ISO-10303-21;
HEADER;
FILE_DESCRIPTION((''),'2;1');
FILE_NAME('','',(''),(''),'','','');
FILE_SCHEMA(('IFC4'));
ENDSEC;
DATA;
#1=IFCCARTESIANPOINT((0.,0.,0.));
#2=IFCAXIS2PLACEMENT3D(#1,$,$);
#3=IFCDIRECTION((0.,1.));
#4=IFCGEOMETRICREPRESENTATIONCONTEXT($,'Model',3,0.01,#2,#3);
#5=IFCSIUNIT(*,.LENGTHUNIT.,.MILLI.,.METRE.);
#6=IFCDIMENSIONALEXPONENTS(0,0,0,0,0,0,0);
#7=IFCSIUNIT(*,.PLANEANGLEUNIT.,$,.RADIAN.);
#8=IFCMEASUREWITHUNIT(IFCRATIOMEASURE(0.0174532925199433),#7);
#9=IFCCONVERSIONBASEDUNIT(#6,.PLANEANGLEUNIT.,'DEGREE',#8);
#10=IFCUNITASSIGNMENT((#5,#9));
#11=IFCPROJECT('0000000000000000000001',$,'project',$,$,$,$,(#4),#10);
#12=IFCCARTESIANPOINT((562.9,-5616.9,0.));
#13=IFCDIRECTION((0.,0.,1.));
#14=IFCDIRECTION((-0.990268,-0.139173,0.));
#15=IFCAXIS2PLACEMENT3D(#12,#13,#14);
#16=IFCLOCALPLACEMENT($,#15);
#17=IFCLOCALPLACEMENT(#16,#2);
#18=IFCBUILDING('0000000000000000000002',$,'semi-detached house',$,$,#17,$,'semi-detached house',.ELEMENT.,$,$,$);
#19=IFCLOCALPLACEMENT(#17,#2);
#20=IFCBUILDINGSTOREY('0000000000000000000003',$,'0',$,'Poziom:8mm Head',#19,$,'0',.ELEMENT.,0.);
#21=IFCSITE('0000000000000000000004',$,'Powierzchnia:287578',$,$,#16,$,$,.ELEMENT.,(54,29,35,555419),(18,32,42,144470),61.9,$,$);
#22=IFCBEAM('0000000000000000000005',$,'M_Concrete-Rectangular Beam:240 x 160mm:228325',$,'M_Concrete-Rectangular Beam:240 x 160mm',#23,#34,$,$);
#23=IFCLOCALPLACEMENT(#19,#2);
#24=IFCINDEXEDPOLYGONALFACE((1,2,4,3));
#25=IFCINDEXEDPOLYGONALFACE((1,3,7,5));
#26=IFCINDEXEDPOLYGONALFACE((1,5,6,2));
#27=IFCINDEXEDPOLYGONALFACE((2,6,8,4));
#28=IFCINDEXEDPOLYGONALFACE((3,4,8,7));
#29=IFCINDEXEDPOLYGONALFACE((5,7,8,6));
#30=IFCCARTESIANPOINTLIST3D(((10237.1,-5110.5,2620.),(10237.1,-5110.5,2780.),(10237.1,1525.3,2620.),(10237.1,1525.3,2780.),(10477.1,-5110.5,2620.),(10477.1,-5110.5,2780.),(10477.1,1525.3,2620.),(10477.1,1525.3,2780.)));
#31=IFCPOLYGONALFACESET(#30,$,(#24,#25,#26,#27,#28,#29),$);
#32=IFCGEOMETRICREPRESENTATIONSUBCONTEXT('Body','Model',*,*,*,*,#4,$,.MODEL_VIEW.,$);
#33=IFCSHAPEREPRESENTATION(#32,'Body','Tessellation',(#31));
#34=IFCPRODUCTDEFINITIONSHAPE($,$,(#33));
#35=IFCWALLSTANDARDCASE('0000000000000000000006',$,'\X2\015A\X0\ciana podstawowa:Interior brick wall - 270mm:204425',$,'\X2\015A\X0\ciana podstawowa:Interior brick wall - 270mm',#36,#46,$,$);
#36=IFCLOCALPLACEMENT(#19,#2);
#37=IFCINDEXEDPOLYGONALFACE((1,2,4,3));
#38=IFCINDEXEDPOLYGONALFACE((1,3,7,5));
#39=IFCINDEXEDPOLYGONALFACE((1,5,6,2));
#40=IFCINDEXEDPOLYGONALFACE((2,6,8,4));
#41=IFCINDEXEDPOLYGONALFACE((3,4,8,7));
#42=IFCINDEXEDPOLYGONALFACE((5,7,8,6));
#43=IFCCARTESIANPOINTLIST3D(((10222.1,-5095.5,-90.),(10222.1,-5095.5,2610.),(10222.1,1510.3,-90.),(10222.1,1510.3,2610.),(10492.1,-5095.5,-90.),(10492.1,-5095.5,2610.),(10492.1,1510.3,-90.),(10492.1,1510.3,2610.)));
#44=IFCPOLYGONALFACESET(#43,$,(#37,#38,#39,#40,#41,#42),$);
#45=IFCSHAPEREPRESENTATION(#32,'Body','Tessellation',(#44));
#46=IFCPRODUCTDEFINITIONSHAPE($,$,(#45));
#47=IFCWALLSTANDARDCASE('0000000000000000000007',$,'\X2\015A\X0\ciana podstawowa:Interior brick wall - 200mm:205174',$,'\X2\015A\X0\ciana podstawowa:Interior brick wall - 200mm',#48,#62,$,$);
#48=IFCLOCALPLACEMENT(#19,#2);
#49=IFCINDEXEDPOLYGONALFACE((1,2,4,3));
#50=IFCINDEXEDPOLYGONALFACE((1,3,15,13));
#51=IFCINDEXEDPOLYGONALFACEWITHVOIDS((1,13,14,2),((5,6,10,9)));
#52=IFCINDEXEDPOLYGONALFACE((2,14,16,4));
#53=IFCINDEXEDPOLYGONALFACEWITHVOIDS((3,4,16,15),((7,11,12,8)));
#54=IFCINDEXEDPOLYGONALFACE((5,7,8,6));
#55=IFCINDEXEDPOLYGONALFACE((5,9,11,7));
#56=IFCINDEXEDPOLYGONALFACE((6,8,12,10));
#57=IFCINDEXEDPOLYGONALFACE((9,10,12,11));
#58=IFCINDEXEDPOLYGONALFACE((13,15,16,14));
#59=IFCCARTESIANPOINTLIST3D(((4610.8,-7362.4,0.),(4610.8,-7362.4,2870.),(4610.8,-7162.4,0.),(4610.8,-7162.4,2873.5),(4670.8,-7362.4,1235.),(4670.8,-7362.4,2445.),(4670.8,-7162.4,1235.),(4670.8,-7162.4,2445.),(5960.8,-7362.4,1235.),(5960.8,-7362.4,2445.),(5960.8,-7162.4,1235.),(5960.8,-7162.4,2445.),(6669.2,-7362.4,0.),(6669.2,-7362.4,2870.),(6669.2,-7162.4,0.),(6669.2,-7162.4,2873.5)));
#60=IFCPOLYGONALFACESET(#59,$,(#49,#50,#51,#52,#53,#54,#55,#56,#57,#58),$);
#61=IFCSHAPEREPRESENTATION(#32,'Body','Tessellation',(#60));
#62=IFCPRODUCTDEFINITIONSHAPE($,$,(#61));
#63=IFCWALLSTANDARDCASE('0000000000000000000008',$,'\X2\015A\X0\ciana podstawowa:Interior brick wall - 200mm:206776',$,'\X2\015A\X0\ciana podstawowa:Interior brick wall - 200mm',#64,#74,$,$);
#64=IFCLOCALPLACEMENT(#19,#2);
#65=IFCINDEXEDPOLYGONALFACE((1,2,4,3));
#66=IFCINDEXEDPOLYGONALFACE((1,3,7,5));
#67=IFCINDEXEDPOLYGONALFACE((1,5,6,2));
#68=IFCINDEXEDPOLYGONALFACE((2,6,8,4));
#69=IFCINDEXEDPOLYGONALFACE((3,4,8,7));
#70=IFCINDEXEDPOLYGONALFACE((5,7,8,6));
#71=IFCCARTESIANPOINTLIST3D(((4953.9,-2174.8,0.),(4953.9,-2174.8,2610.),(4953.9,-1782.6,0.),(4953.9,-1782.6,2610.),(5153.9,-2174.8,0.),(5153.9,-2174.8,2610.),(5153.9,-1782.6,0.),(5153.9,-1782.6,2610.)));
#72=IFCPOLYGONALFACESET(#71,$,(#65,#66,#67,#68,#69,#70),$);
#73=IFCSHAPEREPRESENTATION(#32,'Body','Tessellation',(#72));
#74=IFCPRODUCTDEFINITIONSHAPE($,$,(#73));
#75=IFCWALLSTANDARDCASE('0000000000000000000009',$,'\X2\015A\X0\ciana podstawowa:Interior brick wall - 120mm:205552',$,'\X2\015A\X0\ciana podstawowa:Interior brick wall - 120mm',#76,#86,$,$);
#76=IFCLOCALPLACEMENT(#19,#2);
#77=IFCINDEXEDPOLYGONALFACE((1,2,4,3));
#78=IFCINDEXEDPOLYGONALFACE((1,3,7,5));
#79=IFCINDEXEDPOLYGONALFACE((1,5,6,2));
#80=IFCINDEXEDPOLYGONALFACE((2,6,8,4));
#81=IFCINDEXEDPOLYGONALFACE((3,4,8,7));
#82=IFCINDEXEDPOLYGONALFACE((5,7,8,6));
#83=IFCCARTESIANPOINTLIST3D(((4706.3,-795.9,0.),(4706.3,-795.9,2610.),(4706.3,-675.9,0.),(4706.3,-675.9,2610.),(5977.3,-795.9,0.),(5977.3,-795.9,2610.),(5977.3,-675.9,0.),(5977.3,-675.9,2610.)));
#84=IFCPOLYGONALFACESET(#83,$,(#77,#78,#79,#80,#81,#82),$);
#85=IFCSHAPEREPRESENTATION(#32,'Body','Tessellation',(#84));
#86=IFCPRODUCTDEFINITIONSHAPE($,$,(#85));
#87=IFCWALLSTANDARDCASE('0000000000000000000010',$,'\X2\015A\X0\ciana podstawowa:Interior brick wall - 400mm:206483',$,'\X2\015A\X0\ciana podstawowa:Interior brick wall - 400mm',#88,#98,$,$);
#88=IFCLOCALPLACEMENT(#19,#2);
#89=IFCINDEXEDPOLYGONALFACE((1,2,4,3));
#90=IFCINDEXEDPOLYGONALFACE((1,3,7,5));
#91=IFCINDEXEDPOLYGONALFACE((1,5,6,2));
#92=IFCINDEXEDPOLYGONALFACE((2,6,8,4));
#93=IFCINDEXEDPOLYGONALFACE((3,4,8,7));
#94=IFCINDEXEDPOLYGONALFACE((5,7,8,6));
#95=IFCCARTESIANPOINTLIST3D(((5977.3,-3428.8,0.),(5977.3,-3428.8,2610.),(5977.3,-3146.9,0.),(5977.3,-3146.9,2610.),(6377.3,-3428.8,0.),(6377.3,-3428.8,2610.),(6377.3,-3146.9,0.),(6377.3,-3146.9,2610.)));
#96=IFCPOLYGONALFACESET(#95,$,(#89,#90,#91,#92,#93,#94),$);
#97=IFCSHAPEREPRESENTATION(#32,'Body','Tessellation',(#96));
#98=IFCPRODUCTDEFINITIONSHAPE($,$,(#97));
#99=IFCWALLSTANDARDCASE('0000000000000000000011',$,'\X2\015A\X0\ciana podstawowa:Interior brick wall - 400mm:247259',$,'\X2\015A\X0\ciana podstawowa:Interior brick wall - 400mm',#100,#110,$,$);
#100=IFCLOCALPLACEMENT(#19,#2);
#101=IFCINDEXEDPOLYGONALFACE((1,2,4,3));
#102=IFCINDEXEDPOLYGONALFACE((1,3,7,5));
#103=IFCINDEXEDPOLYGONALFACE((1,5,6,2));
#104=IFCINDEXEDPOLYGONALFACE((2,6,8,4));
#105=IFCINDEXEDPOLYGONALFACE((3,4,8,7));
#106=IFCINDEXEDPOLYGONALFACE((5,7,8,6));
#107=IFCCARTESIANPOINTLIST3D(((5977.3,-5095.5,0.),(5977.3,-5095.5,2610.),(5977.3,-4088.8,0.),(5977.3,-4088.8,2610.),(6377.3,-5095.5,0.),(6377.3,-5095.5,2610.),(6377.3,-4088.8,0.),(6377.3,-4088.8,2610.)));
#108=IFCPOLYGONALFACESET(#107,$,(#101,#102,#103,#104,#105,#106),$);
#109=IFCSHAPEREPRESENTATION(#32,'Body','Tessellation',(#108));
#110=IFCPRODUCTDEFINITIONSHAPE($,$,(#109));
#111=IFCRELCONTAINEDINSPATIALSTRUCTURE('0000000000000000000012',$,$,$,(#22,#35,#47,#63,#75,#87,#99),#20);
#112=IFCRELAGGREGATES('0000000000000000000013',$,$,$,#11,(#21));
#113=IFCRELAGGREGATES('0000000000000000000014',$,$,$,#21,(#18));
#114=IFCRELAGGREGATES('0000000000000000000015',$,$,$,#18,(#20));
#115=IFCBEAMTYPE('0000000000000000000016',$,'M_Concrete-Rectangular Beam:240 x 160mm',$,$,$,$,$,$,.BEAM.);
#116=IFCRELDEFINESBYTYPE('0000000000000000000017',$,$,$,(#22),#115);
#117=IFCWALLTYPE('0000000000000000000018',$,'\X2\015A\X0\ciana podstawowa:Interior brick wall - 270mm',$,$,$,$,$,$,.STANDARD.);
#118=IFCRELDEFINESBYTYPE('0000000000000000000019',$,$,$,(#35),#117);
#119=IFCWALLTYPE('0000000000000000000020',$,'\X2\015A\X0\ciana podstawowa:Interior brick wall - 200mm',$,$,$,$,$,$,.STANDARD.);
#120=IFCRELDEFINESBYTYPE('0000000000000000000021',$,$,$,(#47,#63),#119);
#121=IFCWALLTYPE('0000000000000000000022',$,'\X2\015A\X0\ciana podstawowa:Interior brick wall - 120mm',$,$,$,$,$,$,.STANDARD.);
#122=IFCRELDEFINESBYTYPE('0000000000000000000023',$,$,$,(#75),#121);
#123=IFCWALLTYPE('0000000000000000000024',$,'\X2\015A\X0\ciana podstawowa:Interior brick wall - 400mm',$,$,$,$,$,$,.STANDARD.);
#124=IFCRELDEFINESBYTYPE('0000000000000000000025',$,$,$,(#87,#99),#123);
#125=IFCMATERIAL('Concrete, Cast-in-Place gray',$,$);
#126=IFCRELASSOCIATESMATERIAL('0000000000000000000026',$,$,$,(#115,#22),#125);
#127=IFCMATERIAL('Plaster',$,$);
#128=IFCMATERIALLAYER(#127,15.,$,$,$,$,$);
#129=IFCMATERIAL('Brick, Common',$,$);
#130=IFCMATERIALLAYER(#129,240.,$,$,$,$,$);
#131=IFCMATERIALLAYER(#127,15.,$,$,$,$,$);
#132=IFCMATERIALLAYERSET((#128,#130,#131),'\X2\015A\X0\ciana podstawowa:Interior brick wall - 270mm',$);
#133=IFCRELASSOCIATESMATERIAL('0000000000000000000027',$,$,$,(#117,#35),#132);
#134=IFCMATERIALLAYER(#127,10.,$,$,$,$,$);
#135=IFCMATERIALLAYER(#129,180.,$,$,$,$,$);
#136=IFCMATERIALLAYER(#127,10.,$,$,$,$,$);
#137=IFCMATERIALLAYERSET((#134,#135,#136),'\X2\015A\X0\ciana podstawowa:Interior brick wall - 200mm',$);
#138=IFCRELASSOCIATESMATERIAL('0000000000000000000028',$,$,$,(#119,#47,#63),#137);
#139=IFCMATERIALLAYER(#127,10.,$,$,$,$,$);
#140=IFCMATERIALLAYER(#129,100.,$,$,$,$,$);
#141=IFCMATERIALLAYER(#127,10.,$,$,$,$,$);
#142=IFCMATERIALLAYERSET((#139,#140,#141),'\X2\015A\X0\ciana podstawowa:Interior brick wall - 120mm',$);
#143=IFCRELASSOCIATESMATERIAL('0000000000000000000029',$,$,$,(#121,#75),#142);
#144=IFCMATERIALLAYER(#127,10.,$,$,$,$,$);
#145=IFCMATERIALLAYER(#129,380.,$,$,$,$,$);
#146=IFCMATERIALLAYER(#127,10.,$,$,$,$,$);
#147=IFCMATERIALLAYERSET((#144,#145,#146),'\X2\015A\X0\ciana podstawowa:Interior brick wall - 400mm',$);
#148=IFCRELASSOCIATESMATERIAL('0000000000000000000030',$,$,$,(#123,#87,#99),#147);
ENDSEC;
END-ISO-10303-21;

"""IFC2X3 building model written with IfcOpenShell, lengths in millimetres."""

from ifc_helpers import new_model, entity, si_unit, converted_unit, direction, frame, frame_2d, origin, place, context, subcontext, project, spatial, polyline, rectangle, extrude, clip, bounded_halfspace, material, layer, layer_set, layer_usage, type_object, element, save


model = new_model("IFC2X3")

# Units and contexts
model_context = context("Model", 3, precision=0.01, world=origin(), true_north=direction((0.0, 1.0)))
body_context = subcontext(model_context, "Body", "Model", "MODEL_VIEW")
ifc_project = project(units=[si_unit("LENGTHUNIT", "METRE", prefix="MILLI"), converted_unit("PLANEANGLEUNIT", "DEGREE", entity("IfcRatioMeasure", 0.0174532925199433), si_unit("PLANEANGLEUNIT", "RADIAN"), dimensions=[0, 0, 0, 0, 0, 0, 0])], contexts=[model_context])

# Site, building, storey
site_placement = place(None, frame((562.9, -5616.9, 0.0), z_axis=(0.0, 0.0, 1.0), x_axis=(-0.990268, -0.139173, 0.0)))
site = spatial("IfcSite", under=ifc_project, at=site_placement, Name="Powierzchnia:287578", CompositionType="ELEMENT", RefLatitude=(54, 29, 35, 555419), RefLongitude=(18, 32, 42, 144470), RefElevation=61.9)
building_placement = place(site_placement, origin())
building = spatial("IfcBuilding", under=site, at=building_placement, Name="semi-detached house", LongName="semi-detached house", CompositionType="ELEMENT")
storey_placement = place(building_placement, origin())
storey = spatial("IfcBuildingStorey", under=building, at=storey_placement, Name="0", ObjectType="Poziom:8mm Head", LongName="0", CompositionType="ELEMENT", Elevation=0.0)

# Beam
ifc_material_1 = material(Name="Concrete, Cast-in-Place gray")
beam_type_1 = type_object("IfcBeamType", Name="M_Concrete-Rectangular Beam:240 x 160mm", PredefinedType="BEAM", material=ifc_material_1)
beam_1_placement = place(storey_placement, frame((10357.1, 1865.3, 2780.0), z_axis=(0.0, 0.0, 1.0), x_axis=(0.0, -1.0, 0.0)))
element("IfcBeam", 1, at=beam_1_placement, inside=storey, type_object=beam_type_1, material=ifc_material_1, Name="M_Concrete-Rectangular Beam:240 x 160mm:228325", ObjectType="M_Concrete-Rectangular Beam:240 x 160mm", context=body_context, shape_type="SweptSolid", body=[
    extrude(rectangle(XDim=160.0, YDim=240.0, at=frame_2d((0.0, 0.0), x_axis=(1.0, 0.0))), frame((340.0, 0.0, -80.0), z_axis=(1.0, 0.0, 0.0), x_axis=(0.0, 0.0, -1.0)), (0.0, 0.0, 1.0), 6635.8),
])

# Wall
ifc_material_2 = material(Name="Plaster")
ifc_layer_1 = layer(ifc_material_2, 15.0)
ifc_material_3 = material(Name="Brick, Common")
ifc_layer_2 = layer(ifc_material_3, 240.0)
ifc_layer_3 = layer(ifc_material_2, 15.0)
ifc_layer_set_1 = layer_set([ifc_layer_1, ifc_layer_2, ifc_layer_3], Name="Ściana podstawowa:Interior brick wall - 270mm")
ifc_layer_usage_1 = layer_usage(ifc_layer_set_1, "AXIS2", "NEGATIVE", 135.0)
wall_type_1 = type_object("IfcWallType", Name="Ściana podstawowa:Interior brick wall - 270mm", PredefinedType="STANDARD", material=ifc_layer_set_1)
wall_1_placement = place(storey_placement, frame((10357.1, -5095.5, -90.0), z_axis=(0.0, 0.0, 1.0), x_axis=(0.0, 1.0, 0.0)))
element("IfcWallStandardCase", 2, at=wall_1_placement, inside=storey, type_object=wall_type_1, material=ifc_layer_usage_1, Name="Ściana podstawowa:Interior brick wall - 270mm:204425", ObjectType="Ściana podstawowa:Interior brick wall - 270mm", context=body_context, shape_type="SweptSolid", body=[
    extrude(rectangle(XDim=6605.8, YDim=270.0, at=frame_2d((3302.9, 0.0), x_axis=(-1.0, 0.0))), origin(), (0.0, 0.0, 1.0), 2700.0),
])

# Wall, opening
ifc_layer_4 = layer(ifc_material_2, 10.0)
ifc_layer_5 = layer(ifc_material_3, 180.0)
ifc_layer_6 = layer(ifc_material_2, 10.0)
ifc_layer_set_2 = layer_set([ifc_layer_4, ifc_layer_5, ifc_layer_6], Name="Ściana podstawowa:Interior brick wall - 200mm")
ifc_layer_usage_2 = layer_usage(ifc_layer_set_2, "AXIS2", "NEGATIVE", 100.0)
wall_type_2 = type_object("IfcWallType", Name="Ściana podstawowa:Interior brick wall - 200mm", PredefinedType="STANDARD", material=ifc_layer_set_2)
wall_2_placement = place(storey_placement, frame((6669.2, -7262.4, 0.0), z_axis=(0.0, 0.0, 1.0), x_axis=(-1.0, 0.0, 0.0)))
wall_2 = element("IfcWallStandardCase", 3, at=wall_2_placement, inside=storey, type_object=wall_type_2, material=ifc_layer_usage_2, Name="Ściana podstawowa:Interior brick wall - 200mm:205174", ObjectType="Ściana podstawowa:Interior brick wall - 200mm", context=body_context, shape_type="Clipping", body=[
    clip(clip(extrude(rectangle(XDim=2058.3, YDim=200.0, at=frame_2d((1029.2, 0.0), x_axis=(-1.0, 0.0))), origin(), (0.0, 0.0, 1.0), 2873.5), bounded_halfspace(frame((0.0, -100.0, 2873.5), z_axis=(0.0, 0.017452, 0.999848), x_axis=(-1.0, 0.0, 0.0)), False, frame((0.0, -100.0, 2873.5)), polyline([(0.0, 0.0), (2058.3, 0.0), (2058.3, 200.0), (0.0, 200.0), (0.0, 0.0)]))), bounded_halfspace(frame((2058.3, -100.0, 0.0), z_axis=(0.0, 0.0, 1.0), x_axis=(0.0, 1.0, 0.0)), True, frame((2058.3, -100.0, 0.0), z_axis=(0.0, 0.0, 1.0), x_axis=(0.0, 1.0, 0.0)), polyline([(0.0, 0.0), (200.0, 0.0), (200.0, 2058.3), (0.0, 2058.3), (0.0, 0.0)]))),
])
opening_1_placement = place(wall_2_placement, frame((708.3, -100.0, 1235.0)))
element("IfcOpeningElement", 4, at=opening_1_placement, cuts=wall_2, ObjectType="Opening", context=body_context, shape_type="SweptSolid", body=[
    extrude(rectangle(XDim=1210.0, YDim=1290.0, at=frame_2d((605.0, 645.0), x_axis=(-1.0, 0.0))), frame((0.0, 0.0, 0.0), z_axis=(0.0, 1.0, 0.0), x_axis=(0.0, 0.0, 1.0)), (0.0, 0.0, 1.0), 200.0),
])

# Walls
ifc_layer_usage_3 = layer_usage(ifc_layer_set_2, "AXIS2", "NEGATIVE", 100.0)
wall_3_placement = place(storey_placement, frame((5053.9, -1782.6, 0.0), z_axis=(0.0, 0.0, 1.0), x_axis=(0.0, -1.0, 0.0)))
element("IfcWallStandardCase", 5, at=wall_3_placement, inside=storey, type_object=wall_type_2, material=ifc_layer_usage_3, Name="Ściana podstawowa:Interior brick wall - 200mm:206776", ObjectType="Ściana podstawowa:Interior brick wall - 200mm", context=body_context, shape_type="Clipping", body=[
    clip(extrude(rectangle(XDim=392.1, YDim=200.0, at=frame_2d((196.1, 0.0), x_axis=(-1.0, 0.0))), origin(), (0.0, 0.0, 1.0), 2610.0), bounded_halfspace(frame((392.1, -100.0, 0.0)), True, frame((392.1, -100.0, 0.0)), polyline([(0.0, 0.0), (0.0, 200.0), (-392.1, 200.0), (-392.1, 80.0), (-392.1, 0.0), (-272.1, 0.0), (0.0, 0.0)]))),
])
ifc_layer_7 = layer(ifc_material_2, 10.0)
ifc_layer_8 = layer(ifc_material_3, 100.0)
ifc_layer_9 = layer(ifc_material_2, 10.0)
ifc_layer_set_3 = layer_set([ifc_layer_7, ifc_layer_8, ifc_layer_9], Name="Ściana podstawowa:Interior brick wall - 120mm")
ifc_layer_usage_4 = layer_usage(ifc_layer_set_3, "AXIS2", "NEGATIVE", 60.0)
wall_type_3 = type_object("IfcWallType", Name="Ściana podstawowa:Interior brick wall - 120mm", PredefinedType="STANDARD", material=ifc_layer_set_3)
wall_4_placement = place(storey_placement, frame((5977.3, -735.9, 0.0), z_axis=(0.0, 0.0, 1.0), x_axis=(-1.0, 0.0, 0.0)))
element("IfcWallStandardCase", 6, at=wall_4_placement, inside=storey, type_object=wall_type_3, material=ifc_layer_usage_4, Name="Ściana podstawowa:Interior brick wall - 120mm:205552", ObjectType="Ściana podstawowa:Interior brick wall - 120mm", context=body_context, shape_type="Clipping", body=[
    clip(extrude(rectangle(XDim=1271.0, YDim=120.0, at=frame_2d((635.5, 0.0), x_axis=(-1.0, 0.0))), origin(), (0.0, 0.0, 1.0), 2610.0), bounded_halfspace(frame((1271.0, -60.0, 0.0), z_axis=(0.0, 0.0, 1.0), x_axis=(0.0, 1.0, 0.0)), True, frame((1271.0, -60.0, 0.0), z_axis=(0.0, 0.0, 1.0), x_axis=(0.0, 1.0, 0.0)), polyline([(0.0, 0.0), (120.0, 0.0), (120.0, 1271.0), (0.0, 1271.0), (0.0, 0.0)]))),
])
ifc_layer_10 = layer(ifc_material_2, 10.0)
ifc_layer_11 = layer(ifc_material_3, 380.0)
ifc_layer_12 = layer(ifc_material_2, 10.0)
ifc_layer_set_4 = layer_set([ifc_layer_10, ifc_layer_11, ifc_layer_12], Name="Ściana podstawowa:Interior brick wall - 400mm")
ifc_layer_usage_5 = layer_usage(ifc_layer_set_4, "AXIS2", "POSITIVE", -200.0)
wall_type_4 = type_object("IfcWallType", Name="Ściana podstawowa:Interior brick wall - 400mm", PredefinedType="STANDARD", material=ifc_layer_set_4)
wall_5_placement = place(storey_placement, frame((6177.3, -3146.9, 0.0), z_axis=(0.0, 0.0, 1.0), x_axis=(0.0, -1.0, 0.0)))
element("IfcWallStandardCase", 7, at=wall_5_placement, inside=storey, type_object=wall_type_4, material=ifc_layer_usage_5, Name="Ściana podstawowa:Interior brick wall - 400mm:206483", ObjectType="Ściana podstawowa:Interior brick wall - 400mm", context=body_context, shape_type="Clipping", body=[
    clip(extrude(rectangle(XDim=281.9, YDim=400.0, at=frame_2d((141.0, 0.0), x_axis=(-1.0, 0.0))), origin(), (0.0, 0.0, 1.0), 2610.0), bounded_halfspace(frame((281.9, -200.0, 0.0)), True, frame((281.9, -200.0, 0.0)), polyline([(0.0, 0.0), (0.0, 120.0), (0.0, 277.4), (0.0, 280.0), (0.0, 400.0), (-281.9, 400.0), (-281.9, 270.0), (-281.9, 0.0), (0.0, 0.0)]))),
])
ifc_layer_usage_6 = layer_usage(ifc_layer_set_4, "AXIS2", "POSITIVE", -200.0)
wall_6_placement = place(storey_placement, frame((6177.3, -4088.8, 0.0), z_axis=(0.0, 0.0, 1.0), x_axis=(0.0, -1.0, 0.0)))
element("IfcWallStandardCase", 8, at=wall_6_placement, inside=storey, type_object=wall_type_4, material=ifc_layer_usage_6, Name="Ściana podstawowa:Interior brick wall - 400mm:247259", ObjectType="Ściana podstawowa:Interior brick wall - 400mm", context=body_context, shape_type="Clipping", body=[
    clip(extrude(rectangle(XDim=1006.7, YDim=400.0, at=frame_2d((503.4, 0.0), x_axis=(-1.0, 0.0))), origin(), (0.0, 0.0, 1.0), 2610.0), bounded_halfspace(frame((1006.7, -200.0, 0.0)), True, frame((1006.7, -200.0, 0.0)), polyline([(0.0, 0.0), (0.0, 400.0), (-1006.7, 400.0), (-1006.7, 280.0), (-1006.7, 277.4), (-1006.7, 134.0), (-1006.7, 120.0), (-1006.7, 0.0), (0.0, 0.0)]))),
])

save(model, "model.ifc")
